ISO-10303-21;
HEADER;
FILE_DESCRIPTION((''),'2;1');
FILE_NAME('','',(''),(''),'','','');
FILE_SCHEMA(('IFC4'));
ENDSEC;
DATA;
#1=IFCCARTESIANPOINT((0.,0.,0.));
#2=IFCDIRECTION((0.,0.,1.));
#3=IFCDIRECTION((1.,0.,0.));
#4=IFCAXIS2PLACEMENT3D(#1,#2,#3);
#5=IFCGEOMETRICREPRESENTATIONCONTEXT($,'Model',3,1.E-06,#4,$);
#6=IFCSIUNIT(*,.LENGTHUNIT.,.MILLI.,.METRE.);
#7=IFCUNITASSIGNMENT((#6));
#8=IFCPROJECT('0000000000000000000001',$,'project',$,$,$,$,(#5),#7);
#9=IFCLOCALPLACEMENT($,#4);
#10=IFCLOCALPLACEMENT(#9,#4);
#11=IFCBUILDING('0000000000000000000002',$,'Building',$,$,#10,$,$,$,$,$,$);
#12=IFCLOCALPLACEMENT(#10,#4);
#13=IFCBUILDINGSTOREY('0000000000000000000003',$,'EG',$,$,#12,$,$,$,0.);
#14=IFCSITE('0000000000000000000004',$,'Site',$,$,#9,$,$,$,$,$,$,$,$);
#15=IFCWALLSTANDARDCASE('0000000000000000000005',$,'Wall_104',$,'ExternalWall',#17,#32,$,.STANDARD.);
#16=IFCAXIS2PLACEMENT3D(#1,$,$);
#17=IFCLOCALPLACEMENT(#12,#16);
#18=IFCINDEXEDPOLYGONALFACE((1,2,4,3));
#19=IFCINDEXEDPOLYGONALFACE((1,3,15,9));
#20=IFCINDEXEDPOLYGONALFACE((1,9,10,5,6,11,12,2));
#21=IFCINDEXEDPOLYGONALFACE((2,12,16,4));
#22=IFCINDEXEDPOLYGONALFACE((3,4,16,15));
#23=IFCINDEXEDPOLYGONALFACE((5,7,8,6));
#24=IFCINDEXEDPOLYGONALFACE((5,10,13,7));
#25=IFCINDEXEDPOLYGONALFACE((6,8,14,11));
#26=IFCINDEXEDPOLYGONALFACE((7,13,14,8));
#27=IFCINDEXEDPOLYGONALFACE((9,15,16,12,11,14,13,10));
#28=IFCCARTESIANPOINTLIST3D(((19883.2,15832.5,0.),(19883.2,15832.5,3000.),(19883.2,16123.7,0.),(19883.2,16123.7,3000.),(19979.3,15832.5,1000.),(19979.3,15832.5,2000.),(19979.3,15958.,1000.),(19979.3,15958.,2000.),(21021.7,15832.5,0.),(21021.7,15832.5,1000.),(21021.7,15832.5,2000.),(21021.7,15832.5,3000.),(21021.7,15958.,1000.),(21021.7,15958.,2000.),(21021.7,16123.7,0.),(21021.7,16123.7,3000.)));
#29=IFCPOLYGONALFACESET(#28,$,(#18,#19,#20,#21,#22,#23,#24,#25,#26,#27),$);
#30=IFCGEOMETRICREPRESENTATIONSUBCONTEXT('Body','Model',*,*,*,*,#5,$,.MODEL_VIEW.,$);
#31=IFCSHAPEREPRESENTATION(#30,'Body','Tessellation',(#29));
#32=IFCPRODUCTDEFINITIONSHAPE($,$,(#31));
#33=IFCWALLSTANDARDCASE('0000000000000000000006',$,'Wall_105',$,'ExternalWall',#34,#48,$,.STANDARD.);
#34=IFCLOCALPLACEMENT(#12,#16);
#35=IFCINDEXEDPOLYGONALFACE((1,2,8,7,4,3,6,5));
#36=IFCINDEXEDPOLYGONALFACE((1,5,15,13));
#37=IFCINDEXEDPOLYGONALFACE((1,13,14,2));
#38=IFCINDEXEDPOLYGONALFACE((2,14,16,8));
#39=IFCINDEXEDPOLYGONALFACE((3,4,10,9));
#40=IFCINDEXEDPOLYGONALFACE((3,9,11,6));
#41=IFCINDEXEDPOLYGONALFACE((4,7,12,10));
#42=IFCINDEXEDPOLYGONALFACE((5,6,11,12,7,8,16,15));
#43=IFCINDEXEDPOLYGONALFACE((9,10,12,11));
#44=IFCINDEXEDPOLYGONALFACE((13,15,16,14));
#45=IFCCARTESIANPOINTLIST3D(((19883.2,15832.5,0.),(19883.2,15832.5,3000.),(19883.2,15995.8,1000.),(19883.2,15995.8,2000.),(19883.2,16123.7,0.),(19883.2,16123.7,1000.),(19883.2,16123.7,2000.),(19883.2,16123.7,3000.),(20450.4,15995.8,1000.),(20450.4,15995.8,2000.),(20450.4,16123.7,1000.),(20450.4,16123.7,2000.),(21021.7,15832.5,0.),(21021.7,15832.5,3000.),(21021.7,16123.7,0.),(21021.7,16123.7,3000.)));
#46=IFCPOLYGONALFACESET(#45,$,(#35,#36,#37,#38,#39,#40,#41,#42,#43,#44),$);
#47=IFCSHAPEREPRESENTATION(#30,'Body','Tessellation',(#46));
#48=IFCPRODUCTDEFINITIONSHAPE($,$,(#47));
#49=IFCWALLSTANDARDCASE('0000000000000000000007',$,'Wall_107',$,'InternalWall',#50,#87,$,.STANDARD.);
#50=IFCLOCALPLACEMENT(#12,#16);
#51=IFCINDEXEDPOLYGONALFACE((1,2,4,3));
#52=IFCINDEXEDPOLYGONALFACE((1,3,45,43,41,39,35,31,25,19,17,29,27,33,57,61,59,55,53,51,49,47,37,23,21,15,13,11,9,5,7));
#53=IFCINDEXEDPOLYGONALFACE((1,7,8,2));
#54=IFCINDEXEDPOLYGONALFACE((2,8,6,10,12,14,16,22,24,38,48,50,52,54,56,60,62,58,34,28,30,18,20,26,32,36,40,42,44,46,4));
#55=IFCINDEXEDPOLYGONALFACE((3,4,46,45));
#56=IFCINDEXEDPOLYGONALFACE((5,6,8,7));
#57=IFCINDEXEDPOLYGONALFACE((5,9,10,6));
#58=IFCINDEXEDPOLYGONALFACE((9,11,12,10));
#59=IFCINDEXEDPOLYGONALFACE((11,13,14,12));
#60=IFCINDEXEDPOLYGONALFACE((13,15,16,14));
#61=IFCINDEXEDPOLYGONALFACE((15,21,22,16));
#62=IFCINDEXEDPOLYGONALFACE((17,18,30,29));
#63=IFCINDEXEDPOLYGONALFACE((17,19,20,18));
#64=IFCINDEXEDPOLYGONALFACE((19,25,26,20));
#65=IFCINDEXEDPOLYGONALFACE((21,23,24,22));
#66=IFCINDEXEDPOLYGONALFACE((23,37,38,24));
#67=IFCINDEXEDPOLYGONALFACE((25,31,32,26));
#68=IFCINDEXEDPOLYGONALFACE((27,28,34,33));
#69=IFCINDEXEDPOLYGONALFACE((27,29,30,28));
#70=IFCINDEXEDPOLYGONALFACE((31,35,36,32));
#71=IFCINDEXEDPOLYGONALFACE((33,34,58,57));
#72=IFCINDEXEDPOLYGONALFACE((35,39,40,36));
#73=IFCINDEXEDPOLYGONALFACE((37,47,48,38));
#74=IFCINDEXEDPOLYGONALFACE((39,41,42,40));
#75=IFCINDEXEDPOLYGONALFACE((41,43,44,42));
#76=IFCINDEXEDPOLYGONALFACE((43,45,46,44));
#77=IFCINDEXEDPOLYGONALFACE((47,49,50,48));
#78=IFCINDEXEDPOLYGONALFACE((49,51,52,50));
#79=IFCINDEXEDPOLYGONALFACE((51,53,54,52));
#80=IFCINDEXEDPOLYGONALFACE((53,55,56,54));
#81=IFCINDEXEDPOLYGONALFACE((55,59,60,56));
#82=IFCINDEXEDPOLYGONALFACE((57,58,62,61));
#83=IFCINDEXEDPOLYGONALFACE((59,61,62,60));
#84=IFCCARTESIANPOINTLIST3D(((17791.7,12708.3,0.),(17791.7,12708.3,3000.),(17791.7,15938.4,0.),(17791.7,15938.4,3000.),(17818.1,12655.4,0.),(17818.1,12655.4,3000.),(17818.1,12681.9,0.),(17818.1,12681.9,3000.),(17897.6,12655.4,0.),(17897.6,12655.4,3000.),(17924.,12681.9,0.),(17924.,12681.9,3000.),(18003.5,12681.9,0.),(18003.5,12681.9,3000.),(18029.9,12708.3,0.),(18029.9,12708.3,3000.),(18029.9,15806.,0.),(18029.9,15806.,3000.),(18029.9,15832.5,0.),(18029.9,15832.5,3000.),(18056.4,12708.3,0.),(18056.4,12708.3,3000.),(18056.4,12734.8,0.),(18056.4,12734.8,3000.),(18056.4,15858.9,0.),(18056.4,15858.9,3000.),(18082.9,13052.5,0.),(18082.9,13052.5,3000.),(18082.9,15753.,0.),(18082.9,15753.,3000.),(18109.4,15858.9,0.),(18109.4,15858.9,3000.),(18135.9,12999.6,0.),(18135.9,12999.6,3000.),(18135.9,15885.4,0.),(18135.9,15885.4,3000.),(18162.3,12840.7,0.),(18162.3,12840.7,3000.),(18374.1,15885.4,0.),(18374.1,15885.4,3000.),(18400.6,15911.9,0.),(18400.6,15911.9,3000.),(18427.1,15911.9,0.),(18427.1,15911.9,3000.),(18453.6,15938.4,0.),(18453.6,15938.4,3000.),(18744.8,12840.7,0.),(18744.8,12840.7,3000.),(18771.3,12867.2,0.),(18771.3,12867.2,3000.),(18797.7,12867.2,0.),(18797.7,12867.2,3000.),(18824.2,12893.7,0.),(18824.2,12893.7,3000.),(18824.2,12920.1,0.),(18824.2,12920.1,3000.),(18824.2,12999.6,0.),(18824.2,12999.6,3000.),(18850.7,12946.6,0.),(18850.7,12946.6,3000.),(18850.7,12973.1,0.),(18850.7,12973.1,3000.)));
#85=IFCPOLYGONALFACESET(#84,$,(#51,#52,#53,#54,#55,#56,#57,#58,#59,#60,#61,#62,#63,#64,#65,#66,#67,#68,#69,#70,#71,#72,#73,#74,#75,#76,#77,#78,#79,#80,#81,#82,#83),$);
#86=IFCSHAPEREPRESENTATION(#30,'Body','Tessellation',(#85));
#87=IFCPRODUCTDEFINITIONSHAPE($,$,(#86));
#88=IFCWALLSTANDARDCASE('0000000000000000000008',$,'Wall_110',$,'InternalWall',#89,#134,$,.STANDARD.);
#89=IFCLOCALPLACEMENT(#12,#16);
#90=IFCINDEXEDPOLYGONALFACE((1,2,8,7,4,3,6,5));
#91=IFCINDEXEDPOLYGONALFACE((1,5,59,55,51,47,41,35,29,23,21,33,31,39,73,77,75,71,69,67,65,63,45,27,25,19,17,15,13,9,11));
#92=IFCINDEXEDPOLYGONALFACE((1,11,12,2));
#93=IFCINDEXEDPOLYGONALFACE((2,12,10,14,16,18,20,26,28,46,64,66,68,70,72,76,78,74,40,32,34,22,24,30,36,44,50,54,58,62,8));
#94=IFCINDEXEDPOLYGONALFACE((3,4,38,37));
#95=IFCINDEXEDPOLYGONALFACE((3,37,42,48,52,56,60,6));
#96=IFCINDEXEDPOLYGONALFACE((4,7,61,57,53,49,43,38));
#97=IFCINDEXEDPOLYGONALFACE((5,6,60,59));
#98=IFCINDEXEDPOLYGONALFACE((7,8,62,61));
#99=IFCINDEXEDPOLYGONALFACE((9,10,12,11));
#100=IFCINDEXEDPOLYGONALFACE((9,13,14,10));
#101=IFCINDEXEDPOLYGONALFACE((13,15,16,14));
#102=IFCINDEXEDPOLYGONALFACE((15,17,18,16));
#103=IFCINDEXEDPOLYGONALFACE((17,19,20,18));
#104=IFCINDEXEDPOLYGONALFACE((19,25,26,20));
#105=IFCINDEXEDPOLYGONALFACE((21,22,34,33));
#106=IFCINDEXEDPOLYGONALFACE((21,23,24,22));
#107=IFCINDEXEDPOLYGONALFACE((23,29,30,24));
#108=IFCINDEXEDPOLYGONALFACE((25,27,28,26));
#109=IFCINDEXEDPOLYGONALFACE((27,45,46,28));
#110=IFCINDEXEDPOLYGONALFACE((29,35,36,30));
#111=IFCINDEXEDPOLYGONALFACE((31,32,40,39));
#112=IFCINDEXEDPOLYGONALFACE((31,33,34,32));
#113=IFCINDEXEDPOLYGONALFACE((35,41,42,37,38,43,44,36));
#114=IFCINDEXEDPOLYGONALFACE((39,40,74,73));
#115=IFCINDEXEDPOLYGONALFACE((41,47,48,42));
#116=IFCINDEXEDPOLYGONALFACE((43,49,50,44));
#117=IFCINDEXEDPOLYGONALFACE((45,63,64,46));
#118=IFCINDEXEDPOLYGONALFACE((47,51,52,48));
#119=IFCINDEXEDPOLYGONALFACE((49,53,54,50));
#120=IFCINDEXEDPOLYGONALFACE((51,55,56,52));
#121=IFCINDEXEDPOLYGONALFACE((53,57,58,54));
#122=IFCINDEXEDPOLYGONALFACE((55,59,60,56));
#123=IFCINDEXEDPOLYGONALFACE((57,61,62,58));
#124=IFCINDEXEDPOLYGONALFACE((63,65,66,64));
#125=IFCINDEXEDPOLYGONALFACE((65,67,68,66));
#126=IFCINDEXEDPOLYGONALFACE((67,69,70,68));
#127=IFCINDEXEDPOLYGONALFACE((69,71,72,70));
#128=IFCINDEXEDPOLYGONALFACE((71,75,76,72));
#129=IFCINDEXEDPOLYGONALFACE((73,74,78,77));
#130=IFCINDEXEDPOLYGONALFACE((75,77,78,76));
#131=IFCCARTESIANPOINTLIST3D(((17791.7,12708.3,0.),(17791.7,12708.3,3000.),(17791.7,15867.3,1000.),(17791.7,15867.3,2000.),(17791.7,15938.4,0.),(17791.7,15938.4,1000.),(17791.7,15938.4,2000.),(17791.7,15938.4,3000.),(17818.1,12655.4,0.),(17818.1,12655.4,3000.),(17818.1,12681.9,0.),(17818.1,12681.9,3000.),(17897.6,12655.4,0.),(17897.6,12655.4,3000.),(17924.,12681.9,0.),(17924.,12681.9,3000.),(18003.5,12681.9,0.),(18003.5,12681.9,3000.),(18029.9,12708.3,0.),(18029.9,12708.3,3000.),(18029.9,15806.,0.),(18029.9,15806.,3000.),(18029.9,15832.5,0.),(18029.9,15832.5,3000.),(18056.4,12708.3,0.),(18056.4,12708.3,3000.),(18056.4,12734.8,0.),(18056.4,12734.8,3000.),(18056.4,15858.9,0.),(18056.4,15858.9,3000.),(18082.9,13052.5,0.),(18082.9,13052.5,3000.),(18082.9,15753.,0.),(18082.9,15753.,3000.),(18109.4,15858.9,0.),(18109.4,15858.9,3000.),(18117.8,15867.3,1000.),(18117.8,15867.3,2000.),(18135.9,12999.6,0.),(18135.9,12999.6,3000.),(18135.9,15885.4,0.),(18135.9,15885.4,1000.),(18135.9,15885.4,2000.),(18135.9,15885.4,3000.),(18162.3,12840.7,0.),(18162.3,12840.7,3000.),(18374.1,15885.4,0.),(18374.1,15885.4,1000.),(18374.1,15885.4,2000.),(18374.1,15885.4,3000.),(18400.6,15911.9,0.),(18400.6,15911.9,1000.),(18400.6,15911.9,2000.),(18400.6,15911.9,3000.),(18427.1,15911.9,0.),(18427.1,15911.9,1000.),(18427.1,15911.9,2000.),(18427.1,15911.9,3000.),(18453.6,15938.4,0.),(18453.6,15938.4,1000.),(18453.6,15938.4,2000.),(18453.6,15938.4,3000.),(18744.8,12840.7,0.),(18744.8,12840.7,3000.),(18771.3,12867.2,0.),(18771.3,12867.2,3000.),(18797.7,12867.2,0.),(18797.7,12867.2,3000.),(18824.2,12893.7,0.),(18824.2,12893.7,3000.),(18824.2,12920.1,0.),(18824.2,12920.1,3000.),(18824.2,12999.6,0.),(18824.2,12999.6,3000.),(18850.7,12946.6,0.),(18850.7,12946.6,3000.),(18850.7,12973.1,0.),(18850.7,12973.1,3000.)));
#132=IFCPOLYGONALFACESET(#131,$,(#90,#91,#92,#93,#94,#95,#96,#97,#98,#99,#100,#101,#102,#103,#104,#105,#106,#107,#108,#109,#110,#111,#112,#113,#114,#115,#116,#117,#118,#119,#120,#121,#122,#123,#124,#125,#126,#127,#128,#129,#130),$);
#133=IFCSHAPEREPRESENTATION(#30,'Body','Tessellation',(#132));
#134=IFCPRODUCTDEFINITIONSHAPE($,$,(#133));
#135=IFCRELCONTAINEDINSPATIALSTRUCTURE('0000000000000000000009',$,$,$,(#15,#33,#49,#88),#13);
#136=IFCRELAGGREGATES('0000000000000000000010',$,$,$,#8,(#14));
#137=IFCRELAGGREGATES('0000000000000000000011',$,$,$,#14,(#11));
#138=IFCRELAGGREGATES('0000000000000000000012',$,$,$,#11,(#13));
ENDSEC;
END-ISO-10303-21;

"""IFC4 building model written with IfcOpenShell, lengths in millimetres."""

from ifc_helpers import new_model, si_unit, frame, origin_with_axes, place, context, subcontext, project, spatial, polyline, rectangle, outline, extrude, element, save


model = new_model("IFC4")

# Units and contexts
model_context = context("Model", 3, precision=1e-06, world=origin_with_axes())
body_context = subcontext(model_context, "Body", "Model", "MODEL_VIEW")
ifc_project = project(units=[si_unit("LENGTHUNIT", "METRE", prefix="MILLI")], contexts=[model_context])

# Site, building, storey
site_placement = place(None, origin_with_axes())
site = spatial("IfcSite", under=ifc_project, at=site_placement, Name="Site")
building_placement = place(site_placement, origin_with_axes())
building = spatial("IfcBuilding", under=site, at=building_placement, Name="Building")
storey_placement = place(building_placement, origin_with_axes())
storey = spatial("IfcBuildingStorey", under=building, at=storey_placement, Name="EG", Elevation=0.0)

# Walls, openings
wall_1_placement = place(storey_placement, origin_with_axes())
wall_1 = element("IfcWallStandardCase", 1, at=wall_1_placement, inside=storey, Name="Wall_104", ObjectType="ExternalWall", PredefinedType="STANDARD", context=body_context, shape_type="SweptSolid", body=[
    extrude(outline(polyline([(19883.2, 15832.5, 0.0), (19883.2, 16123.7, 0.0), (21021.7, 16123.7, 0.0), (21021.7, 15832.5, 0.0), (19883.2, 15832.5, 0.0)])), origin_with_axes(), (0.0, 0.0, 1.0), 3000.0),
])
opening_1_placement = place(wall_1_placement, origin_with_axes())
element("IfcOpeningElement", 2, at=opening_1_placement, inside=storey, cuts=wall_1, context=body_context, shape_type="SweptSolid", body=[
    extrude(rectangle(XDim=2096.8, YDim=240.0), frame((21027.7, 15838.0, 1000.0), z_axis=(0.0, 0.0, 1.0), x_axis=(1.0, 0.0, 0.0)), (0.0, 0.0, 1.0), 1000.0),
])
wall_2_placement = place(storey_placement, origin_with_axes())
wall_2 = element("IfcWallStandardCase", 3, at=wall_2_placement, inside=storey, Name="Wall_105", ObjectType="ExternalWall", PredefinedType="STANDARD", context=body_context, shape_type="SweptSolid", body=[
    extrude(outline(polyline([(19883.2, 15832.5, 0.0), (19883.2, 16123.7, 0.0), (21021.7, 16123.7, 0.0), (21021.7, 15832.5, 0.0), (19883.2, 15832.5, 0.0)])), origin_with_axes(), (0.0, 0.0, 1.0), 3000.0),
])
opening_2_placement = place(wall_2_placement, origin_with_axes())
element("IfcOpeningElement", 4, at=opening_2_placement, inside=storey, cuts=wall_2, context=body_context, shape_type="SweptSolid", body=[
    extrude(rectangle(XDim=1123.3, YDim=240.0), frame((19888.8, 16115.8, 1000.0), z_axis=(0.0, 0.0, 1.0), x_axis=(1.0, 0.0, 0.0)), (0.0, 0.0, 1.0), 1000.0),
])

# Wall
for number, where, z_axis, x_axis, name in (
    (5, (0.0, 0.0, 0.0), (0.0, 0.0, 1.0), (1.0, 0.0, 0.0), "Wall_107"),
):
    element("IfcWallStandardCase", number, at=place(storey_placement, frame(where, z_axis=z_axis, x_axis=x_axis)), inside=storey, Name=name, ObjectType="InternalWall", PredefinedType="STANDARD", context=body_context, shape_type="SweptSolid", body=[
        extrude(outline(polyline([(17818.1, 12655.4, 0.0), (17818.1, 12681.9, 0.0), (17791.7, 12708.3, 0.0), (17791.7, 15938.4, 0.0), (18453.6, 15938.4, 0.0), (18427.1, 15911.9, 0.0), (18400.6, 15911.9, 0.0), (18374.1, 15885.4, 0.0), (18135.9, 15885.4, 0.0), (18109.4, 15858.9, 0.0), (18056.4, 15858.9, 0.0), (18029.9, 15832.5, 0.0), (18029.9, 15806.0, 0.0), (18082.9, 15753.0, 0.0), (18082.9, 13052.5, 0.0), (18135.9, 12999.6, 0.0), (18824.2, 12999.6, 0.0), (18850.7, 12973.1, 0.0), (18850.7, 12946.6, 0.0), (18824.2, 12920.1, 0.0), (18824.2, 12893.7, 0.0), (18797.7, 12867.2, 0.0), (18771.3, 12867.2, 0.0), (18744.8, 12840.7, 0.0), (18162.3, 12840.7, 0.0), (18056.4, 12734.8, 0.0), (18056.4, 12708.3, 0.0), (18029.9, 12708.3, 0.0), (18003.5, 12681.9, 0.0), (17924.0, 12681.9, 0.0), (17897.6, 12655.4, 0.0), (17818.1, 12655.4, 0.0)])), origin_with_axes(), (0.0, 0.0, 1.0), 3000.0),
    ])

# Wall, opening
wall_3_placement = place(storey_placement, origin_with_axes())
wall_3 = element("IfcWallStandardCase", 6, at=wall_3_placement, inside=storey, Name="Wall_110", ObjectType="InternalWall", PredefinedType="STANDARD", context=body_context, shape_type="SweptSolid", body=[
    extrude(outline(polyline([(17818.1, 12655.4, 0.0), (17818.1, 12681.9, 0.0), (17791.7, 12708.3, 0.0), (17791.7, 15938.4, 0.0), (18453.6, 15938.4, 0.0), (18427.1, 15911.9, 0.0), (18400.6, 15911.9, 0.0), (18374.1, 15885.4, 0.0), (18135.9, 15885.4, 0.0), (18109.4, 15858.9, 0.0), (18056.4, 15858.9, 0.0), (18029.9, 15832.5, 0.0), (18029.9, 15806.0, 0.0), (18082.9, 15753.0, 0.0), (18082.9, 13052.5, 0.0), (18135.9, 12999.6, 0.0), (18824.2, 12999.6, 0.0), (18850.7, 12973.1, 0.0), (18850.7, 12946.6, 0.0), (18824.2, 12920.1, 0.0), (18824.2, 12893.7, 0.0), (18797.7, 12867.2, 0.0), (18771.3, 12867.2, 0.0), (18744.8, 12840.7, 0.0), (18162.3, 12840.7, 0.0), (18056.4, 12734.8, 0.0), (18056.4, 12708.3, 0.0), (18029.9, 12708.3, 0.0), (18003.5, 12681.9, 0.0), (17924.0, 12681.9, 0.0), (17897.6, 12655.4, 0.0), (17818.1, 12655.4, 0.0)])), origin_with_axes(), (0.0, 0.0, 1.0), 3000.0),
])
opening_3_placement = place(wall_3_placement, origin_with_axes())
element("IfcOpeningElement", 7, at=opening_3_placement, inside=storey, cuts=wall_3, context=body_context, shape_type="SweptSolid", body=[
    extrude(rectangle(XDim=1985.7, YDim=115.0), frame((18409.0, 15924.8, 1000.0), z_axis=(0.0, 0.0, 1.0), x_axis=(1.0, 0.0, 0.0)), (0.0, 0.0, 1.0), 1000.0),
])

save(model, "model.ifc")
